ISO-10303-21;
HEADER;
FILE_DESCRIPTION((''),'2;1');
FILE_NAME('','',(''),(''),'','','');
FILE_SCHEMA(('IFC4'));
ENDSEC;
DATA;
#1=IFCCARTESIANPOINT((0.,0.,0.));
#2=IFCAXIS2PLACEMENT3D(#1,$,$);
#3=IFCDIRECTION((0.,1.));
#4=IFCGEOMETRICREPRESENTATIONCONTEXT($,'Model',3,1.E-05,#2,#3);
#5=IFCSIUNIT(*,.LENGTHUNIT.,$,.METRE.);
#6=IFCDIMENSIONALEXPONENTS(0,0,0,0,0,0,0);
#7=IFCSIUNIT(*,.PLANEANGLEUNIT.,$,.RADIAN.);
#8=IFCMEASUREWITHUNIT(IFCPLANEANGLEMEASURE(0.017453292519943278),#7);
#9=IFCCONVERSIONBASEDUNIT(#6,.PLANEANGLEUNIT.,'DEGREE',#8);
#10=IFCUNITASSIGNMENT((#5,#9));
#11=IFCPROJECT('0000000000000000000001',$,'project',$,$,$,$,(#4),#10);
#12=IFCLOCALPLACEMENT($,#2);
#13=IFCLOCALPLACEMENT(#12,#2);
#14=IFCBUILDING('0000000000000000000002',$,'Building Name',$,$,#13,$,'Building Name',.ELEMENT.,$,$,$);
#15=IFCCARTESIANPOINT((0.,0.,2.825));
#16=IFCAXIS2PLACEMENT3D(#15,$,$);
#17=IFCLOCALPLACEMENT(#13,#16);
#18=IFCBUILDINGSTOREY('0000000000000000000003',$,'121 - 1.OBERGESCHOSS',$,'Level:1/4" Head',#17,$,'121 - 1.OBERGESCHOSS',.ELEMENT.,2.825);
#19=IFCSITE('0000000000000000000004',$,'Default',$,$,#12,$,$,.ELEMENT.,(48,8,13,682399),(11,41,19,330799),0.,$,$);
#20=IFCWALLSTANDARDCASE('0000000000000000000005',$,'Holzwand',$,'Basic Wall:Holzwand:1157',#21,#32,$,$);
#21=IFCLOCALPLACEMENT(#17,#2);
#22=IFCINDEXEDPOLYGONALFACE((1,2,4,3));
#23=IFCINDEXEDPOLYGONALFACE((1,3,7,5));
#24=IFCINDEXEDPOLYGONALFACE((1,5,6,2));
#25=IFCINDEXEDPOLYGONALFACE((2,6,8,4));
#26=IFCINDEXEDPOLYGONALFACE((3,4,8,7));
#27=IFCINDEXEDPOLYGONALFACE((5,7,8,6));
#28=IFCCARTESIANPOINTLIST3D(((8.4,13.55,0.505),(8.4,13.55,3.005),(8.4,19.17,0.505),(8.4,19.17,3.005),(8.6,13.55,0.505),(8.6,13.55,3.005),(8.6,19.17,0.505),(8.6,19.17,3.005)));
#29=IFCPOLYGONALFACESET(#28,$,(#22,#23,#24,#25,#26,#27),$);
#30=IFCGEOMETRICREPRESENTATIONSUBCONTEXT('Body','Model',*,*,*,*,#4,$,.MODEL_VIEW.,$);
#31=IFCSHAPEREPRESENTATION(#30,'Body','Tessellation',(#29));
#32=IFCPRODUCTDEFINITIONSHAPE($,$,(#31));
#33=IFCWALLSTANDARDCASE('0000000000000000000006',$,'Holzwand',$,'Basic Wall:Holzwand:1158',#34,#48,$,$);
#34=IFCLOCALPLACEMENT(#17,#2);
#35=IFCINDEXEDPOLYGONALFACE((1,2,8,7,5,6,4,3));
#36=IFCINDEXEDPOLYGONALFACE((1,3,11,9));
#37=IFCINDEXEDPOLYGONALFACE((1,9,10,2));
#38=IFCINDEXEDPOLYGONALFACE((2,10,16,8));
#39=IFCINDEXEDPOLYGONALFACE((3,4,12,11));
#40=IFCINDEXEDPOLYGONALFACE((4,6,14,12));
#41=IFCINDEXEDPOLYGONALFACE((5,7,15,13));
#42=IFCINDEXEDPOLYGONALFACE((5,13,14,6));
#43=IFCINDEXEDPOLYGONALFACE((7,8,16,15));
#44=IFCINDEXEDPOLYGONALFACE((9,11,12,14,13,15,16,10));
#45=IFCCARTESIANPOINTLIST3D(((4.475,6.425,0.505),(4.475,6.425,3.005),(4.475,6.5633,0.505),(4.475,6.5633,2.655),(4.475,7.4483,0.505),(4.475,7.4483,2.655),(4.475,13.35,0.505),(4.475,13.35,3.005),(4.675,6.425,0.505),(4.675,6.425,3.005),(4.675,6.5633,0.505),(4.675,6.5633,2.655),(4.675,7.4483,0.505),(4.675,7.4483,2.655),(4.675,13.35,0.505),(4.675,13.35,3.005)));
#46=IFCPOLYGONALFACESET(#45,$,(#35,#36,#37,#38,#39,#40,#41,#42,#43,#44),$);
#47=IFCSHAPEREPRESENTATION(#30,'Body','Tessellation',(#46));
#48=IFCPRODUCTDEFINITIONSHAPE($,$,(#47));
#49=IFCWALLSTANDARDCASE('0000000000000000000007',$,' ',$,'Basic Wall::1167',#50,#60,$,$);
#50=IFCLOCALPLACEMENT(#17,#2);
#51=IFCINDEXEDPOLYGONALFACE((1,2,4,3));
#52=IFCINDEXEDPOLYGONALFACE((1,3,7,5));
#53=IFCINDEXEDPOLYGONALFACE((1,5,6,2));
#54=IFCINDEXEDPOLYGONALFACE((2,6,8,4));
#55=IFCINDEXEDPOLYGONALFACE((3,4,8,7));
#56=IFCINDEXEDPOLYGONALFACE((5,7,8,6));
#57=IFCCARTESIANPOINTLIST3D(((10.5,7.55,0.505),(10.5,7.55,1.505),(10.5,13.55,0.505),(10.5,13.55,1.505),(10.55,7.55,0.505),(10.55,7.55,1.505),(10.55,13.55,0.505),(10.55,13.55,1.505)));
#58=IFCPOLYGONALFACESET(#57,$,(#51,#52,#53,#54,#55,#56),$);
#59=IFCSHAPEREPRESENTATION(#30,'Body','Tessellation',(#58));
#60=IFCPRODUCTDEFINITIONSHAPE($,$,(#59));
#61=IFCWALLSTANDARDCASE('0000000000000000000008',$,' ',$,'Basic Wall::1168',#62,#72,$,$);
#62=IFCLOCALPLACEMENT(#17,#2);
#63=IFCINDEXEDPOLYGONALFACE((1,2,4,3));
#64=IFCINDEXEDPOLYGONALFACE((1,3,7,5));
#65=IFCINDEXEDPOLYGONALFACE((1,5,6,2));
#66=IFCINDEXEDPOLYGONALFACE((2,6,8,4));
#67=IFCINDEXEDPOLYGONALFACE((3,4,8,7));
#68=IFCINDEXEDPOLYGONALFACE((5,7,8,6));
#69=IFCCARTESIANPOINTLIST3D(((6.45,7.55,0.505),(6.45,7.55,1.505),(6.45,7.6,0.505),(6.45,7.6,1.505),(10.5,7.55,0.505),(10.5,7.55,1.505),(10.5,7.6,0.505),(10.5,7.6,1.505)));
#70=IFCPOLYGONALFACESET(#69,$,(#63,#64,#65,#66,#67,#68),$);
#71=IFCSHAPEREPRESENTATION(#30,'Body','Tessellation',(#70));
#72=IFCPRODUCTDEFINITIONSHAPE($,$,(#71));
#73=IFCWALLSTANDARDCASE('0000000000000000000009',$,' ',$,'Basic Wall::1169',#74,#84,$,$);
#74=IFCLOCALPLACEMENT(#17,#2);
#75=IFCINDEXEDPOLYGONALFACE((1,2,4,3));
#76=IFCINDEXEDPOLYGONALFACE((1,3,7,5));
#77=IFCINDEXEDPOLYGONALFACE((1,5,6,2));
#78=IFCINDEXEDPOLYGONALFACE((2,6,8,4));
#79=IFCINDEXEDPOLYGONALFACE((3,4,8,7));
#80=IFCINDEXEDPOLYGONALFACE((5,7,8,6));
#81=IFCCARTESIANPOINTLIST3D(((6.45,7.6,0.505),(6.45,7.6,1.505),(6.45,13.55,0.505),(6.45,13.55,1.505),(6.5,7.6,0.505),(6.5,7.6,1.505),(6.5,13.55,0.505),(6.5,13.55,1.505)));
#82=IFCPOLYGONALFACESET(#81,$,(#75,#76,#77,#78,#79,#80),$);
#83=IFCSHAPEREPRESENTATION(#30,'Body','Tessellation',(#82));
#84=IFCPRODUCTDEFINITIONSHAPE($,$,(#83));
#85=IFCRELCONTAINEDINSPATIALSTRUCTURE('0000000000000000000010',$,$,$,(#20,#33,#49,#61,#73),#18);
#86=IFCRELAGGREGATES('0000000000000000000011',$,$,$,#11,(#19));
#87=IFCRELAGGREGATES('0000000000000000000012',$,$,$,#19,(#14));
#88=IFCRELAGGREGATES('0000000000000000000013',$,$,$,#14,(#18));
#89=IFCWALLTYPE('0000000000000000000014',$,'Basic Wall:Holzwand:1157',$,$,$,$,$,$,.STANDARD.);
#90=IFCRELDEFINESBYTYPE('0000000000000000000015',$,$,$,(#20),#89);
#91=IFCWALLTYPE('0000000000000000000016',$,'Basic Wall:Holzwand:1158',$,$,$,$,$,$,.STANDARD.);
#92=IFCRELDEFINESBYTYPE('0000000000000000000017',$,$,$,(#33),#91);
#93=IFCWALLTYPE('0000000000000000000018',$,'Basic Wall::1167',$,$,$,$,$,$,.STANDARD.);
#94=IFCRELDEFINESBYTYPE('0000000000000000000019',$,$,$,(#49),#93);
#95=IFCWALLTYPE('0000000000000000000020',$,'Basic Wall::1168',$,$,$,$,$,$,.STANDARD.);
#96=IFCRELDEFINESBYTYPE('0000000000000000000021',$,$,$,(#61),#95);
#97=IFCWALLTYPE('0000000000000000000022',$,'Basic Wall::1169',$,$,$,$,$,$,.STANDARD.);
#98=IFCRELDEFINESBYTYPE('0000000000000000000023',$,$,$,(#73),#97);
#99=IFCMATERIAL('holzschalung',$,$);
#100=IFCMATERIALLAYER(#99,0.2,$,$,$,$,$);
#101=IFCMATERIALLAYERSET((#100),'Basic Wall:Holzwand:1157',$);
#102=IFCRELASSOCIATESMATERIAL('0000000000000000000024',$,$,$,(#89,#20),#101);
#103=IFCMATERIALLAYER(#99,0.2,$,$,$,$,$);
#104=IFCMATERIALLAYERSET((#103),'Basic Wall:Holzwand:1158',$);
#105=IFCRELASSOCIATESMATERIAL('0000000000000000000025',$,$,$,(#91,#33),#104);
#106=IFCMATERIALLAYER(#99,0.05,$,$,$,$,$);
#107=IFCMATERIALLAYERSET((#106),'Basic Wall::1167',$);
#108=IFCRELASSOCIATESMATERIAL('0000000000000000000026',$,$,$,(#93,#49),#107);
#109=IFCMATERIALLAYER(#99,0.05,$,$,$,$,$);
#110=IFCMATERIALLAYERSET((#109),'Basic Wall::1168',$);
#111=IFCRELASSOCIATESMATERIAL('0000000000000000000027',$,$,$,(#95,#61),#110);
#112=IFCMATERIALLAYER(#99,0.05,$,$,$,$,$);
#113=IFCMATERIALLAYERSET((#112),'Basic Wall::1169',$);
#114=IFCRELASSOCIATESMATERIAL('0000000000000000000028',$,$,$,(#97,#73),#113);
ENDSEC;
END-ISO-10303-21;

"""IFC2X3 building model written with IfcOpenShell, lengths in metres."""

from ifc_helpers import new_model, entity, si_unit, converted_unit, direction, frame, frame_2d, origin, place, context, subcontext, project, spatial, rectangle, extrude, material, layer, layer_set, layer_usage, type_object, element, save


model = new_model("IFC2X3")

# Units and contexts
model_context = context("Model", 3, precision=1e-05, world=origin(), true_north=direction((0.0, 1.0)))
body_context = subcontext(model_context, "Body", "Model", "MODEL_VIEW")
ifc_project = project(units=[si_unit("LENGTHUNIT", "METRE"), converted_unit("PLANEANGLEUNIT", "DEGREE", entity("IfcPlaneAngleMeasure", 0.017453292519943278), si_unit("PLANEANGLEUNIT", "RADIAN"), dimensions=[0, 0, 0, 0, 0, 0, 0])], contexts=[model_context])

# Site, building, storey
site_placement = place(None, origin())
site = spatial("IfcSite", under=ifc_project, at=site_placement, Name="Default", CompositionType="ELEMENT", RefLatitude=(48, 8, 13, 682399), RefLongitude=(11, 41, 19, 330799), RefElevation=0.0)
building_placement = place(site_placement, origin())
building = spatial("IfcBuilding", under=site, at=building_placement, Name="Building Name", LongName="Building Name", CompositionType="ELEMENT")
storey_placement = place(building_placement, frame((0.0, 0.0, 2.825)))
storey = spatial("IfcBuildingStorey", under=building, at=storey_placement, Name="121 - 1.OBERGESCHOSS", ObjectType="Level:1/4\" Head", LongName="121 - 1.OBERGESCHOSS", CompositionType="ELEMENT", Elevation=2.825)

# Shared definitions
ifc_material = material(Name="holzschalung")

# Wall
ifc_layer_1 = layer(ifc_material, 0.2)
ifc_layer_set_1 = layer_set([ifc_layer_1], Name="Basic Wall:Holzwand:1157")
ifc_layer_usage_1 = layer_usage(ifc_layer_set_1, "AXIS2", "NEGATIVE", 0.1)
wall_type_1 = type_object("IfcWallType", Name="Basic Wall:Holzwand:1157", PredefinedType="STANDARD", material=ifc_layer_set_1)
wall_1_placement = place(storey_placement, frame((8.5, 13.55, 0.505), z_axis=(0.0, 0.0, 1.0), x_axis=(0.0, 1.0, 0.0)))
element("IfcWallStandardCase", 1, at=wall_1_placement, inside=storey, type_object=wall_type_1, material=ifc_layer_usage_1, Name="Holzwand", ObjectType="Basic Wall:Holzwand:1157", context=body_context, shape_type="SweptSolid", body=[
    extrude(rectangle(XDim=5.62, YDim=0.2, at=frame_2d((2.81, 0.0), x_axis=(-1.0, 0.0))), origin(), (0.0, 0.0, 1.0), 2.5),
])

# Wall, opening
ifc_layer_2 = layer(ifc_material, 0.2)
ifc_layer_set_2 = layer_set([ifc_layer_2], Name="Basic Wall:Holzwand:1158")
ifc_layer_usage_2 = layer_usage(ifc_layer_set_2, "AXIS2", "NEGATIVE", 0.1)
wall_type_2 = type_object("IfcWallType", Name="Basic Wall:Holzwand:1158", PredefinedType="STANDARD", material=ifc_layer_set_2)
wall_2_placement = place(storey_placement, frame((4.575, 13.35, 0.505), z_axis=(0.0, 0.0, 1.0), x_axis=(0.0, -1.0, 0.0)))
wall_2 = element("IfcWallStandardCase", 2, at=wall_2_placement, inside=storey, type_object=wall_type_2, material=ifc_layer_usage_2, Name="Holzwand", ObjectType="Basic Wall:Holzwand:1158", context=body_context, shape_type="SweptSolid", body=[
    extrude(rectangle(XDim=6.925, YDim=0.2, at=frame_2d((3.4625, 0.0), x_axis=(1.0, 0.0))), origin(), (0.0, 0.0, 1.0), 2.5),
])
opening_1_placement = place(wall_2_placement, frame((13.35, -4.575, -0.505), z_axis=(0.0, 0.0, 1.0), x_axis=(0.0, 1.0, 0.0)))
element("IfcOpeningElement", 3, at=opening_1_placement, cuts=wall_2, ObjectType="Opening", context=body_context, shape_type="SweptSolid", body=[
    extrude(rectangle(XDim=2.3, YDim=0.885, at=frame_2d((0.0, 0.0), x_axis=(0.0, 1.0))), frame((4.473, 7.0058, 1.505), z_axis=(1.0, 0.0, 0.0), x_axis=(0.0, 1.0, 0.0)), (0.0, 0.0, 1.0), 0.204),
])

# Walls
ifc_layer_3 = layer(ifc_material, 0.05)
ifc_layer_set_3 = layer_set([ifc_layer_3], Name="Basic Wall::1167")
ifc_layer_usage_3 = layer_usage(ifc_layer_set_3, "AXIS2", "NEGATIVE", 0.025)
wall_type_3 = type_object("IfcWallType", Name="Basic Wall::1167", PredefinedType="STANDARD", material=ifc_layer_set_3)
wall_3_placement = place(storey_placement, frame((10.525, 13.55, 0.505), z_axis=(0.0, 0.0, 1.0), x_axis=(0.0, -1.0, 0.0)))
element("IfcWallStandardCase", 4, at=wall_3_placement, inside=storey, type_object=wall_type_3, material=ifc_layer_usage_3, Name=" ", ObjectType="Basic Wall::1167", context=body_context, shape_type="SweptSolid", body=[
    extrude(rectangle(XDim=6.0, YDim=0.05, at=frame_2d((3.0, 0.0), x_axis=(-1.0, 0.0))), origin(), (0.0, 0.0, 1.0), 1.0),
])
ifc_layer_4 = layer(ifc_material, 0.05)
ifc_layer_set_4 = layer_set([ifc_layer_4], Name="Basic Wall::1168")
ifc_layer_usage_4 = layer_usage(ifc_layer_set_4, "AXIS2", "NEGATIVE", 0.025)
wall_type_4 = type_object("IfcWallType", Name="Basic Wall::1168", PredefinedType="STANDARD", material=ifc_layer_set_4)
wall_4_placement = place(storey_placement, frame((10.5, 7.575, 0.505), z_axis=(0.0, 0.0, 1.0), x_axis=(-1.0, 0.0, 0.0)))
element("IfcWallStandardCase", 5, at=wall_4_placement, inside=storey, type_object=wall_type_4, material=ifc_layer_usage_4, Name=" ", ObjectType="Basic Wall::1168", context=body_context, shape_type="SweptSolid", body=[
    extrude(rectangle(XDim=4.05, YDim=0.05, at=frame_2d((2.025, 0.0), x_axis=(-1.0, 0.0))), origin(), (0.0, 0.0, 1.0), 1.0),
])
ifc_layer_5 = layer(ifc_material, 0.05)
ifc_layer_set_5 = layer_set([ifc_layer_5], Name="Basic Wall::1169")
ifc_layer_usage_5 = layer_usage(ifc_layer_set_5, "AXIS2", "NEGATIVE", 0.025)
wall_type_5 = type_object("IfcWallType", Name="Basic Wall::1169", PredefinedType="STANDARD", material=ifc_layer_set_5)
wall_5_placement = place(storey_placement, frame((6.475, 7.6, 0.505), z_axis=(0.0, 0.0, 1.0), x_axis=(0.0, 1.0, 0.0)))
element("IfcWallStandardCase", 6, at=wall_5_placement, inside=storey, type_object=wall_type_5, material=ifc_layer_usage_5, Name=" ", ObjectType="Basic Wall::1169", context=body_context, shape_type="SweptSolid", body=[
    extrude(rectangle(XDim=5.95, YDim=0.05, at=frame_2d((2.975, 0.0), x_axis=(-1.0, 0.0))), origin(), (0.0, 0.0, 1.0), 1.0),
])

save(model, "model.ifc")
